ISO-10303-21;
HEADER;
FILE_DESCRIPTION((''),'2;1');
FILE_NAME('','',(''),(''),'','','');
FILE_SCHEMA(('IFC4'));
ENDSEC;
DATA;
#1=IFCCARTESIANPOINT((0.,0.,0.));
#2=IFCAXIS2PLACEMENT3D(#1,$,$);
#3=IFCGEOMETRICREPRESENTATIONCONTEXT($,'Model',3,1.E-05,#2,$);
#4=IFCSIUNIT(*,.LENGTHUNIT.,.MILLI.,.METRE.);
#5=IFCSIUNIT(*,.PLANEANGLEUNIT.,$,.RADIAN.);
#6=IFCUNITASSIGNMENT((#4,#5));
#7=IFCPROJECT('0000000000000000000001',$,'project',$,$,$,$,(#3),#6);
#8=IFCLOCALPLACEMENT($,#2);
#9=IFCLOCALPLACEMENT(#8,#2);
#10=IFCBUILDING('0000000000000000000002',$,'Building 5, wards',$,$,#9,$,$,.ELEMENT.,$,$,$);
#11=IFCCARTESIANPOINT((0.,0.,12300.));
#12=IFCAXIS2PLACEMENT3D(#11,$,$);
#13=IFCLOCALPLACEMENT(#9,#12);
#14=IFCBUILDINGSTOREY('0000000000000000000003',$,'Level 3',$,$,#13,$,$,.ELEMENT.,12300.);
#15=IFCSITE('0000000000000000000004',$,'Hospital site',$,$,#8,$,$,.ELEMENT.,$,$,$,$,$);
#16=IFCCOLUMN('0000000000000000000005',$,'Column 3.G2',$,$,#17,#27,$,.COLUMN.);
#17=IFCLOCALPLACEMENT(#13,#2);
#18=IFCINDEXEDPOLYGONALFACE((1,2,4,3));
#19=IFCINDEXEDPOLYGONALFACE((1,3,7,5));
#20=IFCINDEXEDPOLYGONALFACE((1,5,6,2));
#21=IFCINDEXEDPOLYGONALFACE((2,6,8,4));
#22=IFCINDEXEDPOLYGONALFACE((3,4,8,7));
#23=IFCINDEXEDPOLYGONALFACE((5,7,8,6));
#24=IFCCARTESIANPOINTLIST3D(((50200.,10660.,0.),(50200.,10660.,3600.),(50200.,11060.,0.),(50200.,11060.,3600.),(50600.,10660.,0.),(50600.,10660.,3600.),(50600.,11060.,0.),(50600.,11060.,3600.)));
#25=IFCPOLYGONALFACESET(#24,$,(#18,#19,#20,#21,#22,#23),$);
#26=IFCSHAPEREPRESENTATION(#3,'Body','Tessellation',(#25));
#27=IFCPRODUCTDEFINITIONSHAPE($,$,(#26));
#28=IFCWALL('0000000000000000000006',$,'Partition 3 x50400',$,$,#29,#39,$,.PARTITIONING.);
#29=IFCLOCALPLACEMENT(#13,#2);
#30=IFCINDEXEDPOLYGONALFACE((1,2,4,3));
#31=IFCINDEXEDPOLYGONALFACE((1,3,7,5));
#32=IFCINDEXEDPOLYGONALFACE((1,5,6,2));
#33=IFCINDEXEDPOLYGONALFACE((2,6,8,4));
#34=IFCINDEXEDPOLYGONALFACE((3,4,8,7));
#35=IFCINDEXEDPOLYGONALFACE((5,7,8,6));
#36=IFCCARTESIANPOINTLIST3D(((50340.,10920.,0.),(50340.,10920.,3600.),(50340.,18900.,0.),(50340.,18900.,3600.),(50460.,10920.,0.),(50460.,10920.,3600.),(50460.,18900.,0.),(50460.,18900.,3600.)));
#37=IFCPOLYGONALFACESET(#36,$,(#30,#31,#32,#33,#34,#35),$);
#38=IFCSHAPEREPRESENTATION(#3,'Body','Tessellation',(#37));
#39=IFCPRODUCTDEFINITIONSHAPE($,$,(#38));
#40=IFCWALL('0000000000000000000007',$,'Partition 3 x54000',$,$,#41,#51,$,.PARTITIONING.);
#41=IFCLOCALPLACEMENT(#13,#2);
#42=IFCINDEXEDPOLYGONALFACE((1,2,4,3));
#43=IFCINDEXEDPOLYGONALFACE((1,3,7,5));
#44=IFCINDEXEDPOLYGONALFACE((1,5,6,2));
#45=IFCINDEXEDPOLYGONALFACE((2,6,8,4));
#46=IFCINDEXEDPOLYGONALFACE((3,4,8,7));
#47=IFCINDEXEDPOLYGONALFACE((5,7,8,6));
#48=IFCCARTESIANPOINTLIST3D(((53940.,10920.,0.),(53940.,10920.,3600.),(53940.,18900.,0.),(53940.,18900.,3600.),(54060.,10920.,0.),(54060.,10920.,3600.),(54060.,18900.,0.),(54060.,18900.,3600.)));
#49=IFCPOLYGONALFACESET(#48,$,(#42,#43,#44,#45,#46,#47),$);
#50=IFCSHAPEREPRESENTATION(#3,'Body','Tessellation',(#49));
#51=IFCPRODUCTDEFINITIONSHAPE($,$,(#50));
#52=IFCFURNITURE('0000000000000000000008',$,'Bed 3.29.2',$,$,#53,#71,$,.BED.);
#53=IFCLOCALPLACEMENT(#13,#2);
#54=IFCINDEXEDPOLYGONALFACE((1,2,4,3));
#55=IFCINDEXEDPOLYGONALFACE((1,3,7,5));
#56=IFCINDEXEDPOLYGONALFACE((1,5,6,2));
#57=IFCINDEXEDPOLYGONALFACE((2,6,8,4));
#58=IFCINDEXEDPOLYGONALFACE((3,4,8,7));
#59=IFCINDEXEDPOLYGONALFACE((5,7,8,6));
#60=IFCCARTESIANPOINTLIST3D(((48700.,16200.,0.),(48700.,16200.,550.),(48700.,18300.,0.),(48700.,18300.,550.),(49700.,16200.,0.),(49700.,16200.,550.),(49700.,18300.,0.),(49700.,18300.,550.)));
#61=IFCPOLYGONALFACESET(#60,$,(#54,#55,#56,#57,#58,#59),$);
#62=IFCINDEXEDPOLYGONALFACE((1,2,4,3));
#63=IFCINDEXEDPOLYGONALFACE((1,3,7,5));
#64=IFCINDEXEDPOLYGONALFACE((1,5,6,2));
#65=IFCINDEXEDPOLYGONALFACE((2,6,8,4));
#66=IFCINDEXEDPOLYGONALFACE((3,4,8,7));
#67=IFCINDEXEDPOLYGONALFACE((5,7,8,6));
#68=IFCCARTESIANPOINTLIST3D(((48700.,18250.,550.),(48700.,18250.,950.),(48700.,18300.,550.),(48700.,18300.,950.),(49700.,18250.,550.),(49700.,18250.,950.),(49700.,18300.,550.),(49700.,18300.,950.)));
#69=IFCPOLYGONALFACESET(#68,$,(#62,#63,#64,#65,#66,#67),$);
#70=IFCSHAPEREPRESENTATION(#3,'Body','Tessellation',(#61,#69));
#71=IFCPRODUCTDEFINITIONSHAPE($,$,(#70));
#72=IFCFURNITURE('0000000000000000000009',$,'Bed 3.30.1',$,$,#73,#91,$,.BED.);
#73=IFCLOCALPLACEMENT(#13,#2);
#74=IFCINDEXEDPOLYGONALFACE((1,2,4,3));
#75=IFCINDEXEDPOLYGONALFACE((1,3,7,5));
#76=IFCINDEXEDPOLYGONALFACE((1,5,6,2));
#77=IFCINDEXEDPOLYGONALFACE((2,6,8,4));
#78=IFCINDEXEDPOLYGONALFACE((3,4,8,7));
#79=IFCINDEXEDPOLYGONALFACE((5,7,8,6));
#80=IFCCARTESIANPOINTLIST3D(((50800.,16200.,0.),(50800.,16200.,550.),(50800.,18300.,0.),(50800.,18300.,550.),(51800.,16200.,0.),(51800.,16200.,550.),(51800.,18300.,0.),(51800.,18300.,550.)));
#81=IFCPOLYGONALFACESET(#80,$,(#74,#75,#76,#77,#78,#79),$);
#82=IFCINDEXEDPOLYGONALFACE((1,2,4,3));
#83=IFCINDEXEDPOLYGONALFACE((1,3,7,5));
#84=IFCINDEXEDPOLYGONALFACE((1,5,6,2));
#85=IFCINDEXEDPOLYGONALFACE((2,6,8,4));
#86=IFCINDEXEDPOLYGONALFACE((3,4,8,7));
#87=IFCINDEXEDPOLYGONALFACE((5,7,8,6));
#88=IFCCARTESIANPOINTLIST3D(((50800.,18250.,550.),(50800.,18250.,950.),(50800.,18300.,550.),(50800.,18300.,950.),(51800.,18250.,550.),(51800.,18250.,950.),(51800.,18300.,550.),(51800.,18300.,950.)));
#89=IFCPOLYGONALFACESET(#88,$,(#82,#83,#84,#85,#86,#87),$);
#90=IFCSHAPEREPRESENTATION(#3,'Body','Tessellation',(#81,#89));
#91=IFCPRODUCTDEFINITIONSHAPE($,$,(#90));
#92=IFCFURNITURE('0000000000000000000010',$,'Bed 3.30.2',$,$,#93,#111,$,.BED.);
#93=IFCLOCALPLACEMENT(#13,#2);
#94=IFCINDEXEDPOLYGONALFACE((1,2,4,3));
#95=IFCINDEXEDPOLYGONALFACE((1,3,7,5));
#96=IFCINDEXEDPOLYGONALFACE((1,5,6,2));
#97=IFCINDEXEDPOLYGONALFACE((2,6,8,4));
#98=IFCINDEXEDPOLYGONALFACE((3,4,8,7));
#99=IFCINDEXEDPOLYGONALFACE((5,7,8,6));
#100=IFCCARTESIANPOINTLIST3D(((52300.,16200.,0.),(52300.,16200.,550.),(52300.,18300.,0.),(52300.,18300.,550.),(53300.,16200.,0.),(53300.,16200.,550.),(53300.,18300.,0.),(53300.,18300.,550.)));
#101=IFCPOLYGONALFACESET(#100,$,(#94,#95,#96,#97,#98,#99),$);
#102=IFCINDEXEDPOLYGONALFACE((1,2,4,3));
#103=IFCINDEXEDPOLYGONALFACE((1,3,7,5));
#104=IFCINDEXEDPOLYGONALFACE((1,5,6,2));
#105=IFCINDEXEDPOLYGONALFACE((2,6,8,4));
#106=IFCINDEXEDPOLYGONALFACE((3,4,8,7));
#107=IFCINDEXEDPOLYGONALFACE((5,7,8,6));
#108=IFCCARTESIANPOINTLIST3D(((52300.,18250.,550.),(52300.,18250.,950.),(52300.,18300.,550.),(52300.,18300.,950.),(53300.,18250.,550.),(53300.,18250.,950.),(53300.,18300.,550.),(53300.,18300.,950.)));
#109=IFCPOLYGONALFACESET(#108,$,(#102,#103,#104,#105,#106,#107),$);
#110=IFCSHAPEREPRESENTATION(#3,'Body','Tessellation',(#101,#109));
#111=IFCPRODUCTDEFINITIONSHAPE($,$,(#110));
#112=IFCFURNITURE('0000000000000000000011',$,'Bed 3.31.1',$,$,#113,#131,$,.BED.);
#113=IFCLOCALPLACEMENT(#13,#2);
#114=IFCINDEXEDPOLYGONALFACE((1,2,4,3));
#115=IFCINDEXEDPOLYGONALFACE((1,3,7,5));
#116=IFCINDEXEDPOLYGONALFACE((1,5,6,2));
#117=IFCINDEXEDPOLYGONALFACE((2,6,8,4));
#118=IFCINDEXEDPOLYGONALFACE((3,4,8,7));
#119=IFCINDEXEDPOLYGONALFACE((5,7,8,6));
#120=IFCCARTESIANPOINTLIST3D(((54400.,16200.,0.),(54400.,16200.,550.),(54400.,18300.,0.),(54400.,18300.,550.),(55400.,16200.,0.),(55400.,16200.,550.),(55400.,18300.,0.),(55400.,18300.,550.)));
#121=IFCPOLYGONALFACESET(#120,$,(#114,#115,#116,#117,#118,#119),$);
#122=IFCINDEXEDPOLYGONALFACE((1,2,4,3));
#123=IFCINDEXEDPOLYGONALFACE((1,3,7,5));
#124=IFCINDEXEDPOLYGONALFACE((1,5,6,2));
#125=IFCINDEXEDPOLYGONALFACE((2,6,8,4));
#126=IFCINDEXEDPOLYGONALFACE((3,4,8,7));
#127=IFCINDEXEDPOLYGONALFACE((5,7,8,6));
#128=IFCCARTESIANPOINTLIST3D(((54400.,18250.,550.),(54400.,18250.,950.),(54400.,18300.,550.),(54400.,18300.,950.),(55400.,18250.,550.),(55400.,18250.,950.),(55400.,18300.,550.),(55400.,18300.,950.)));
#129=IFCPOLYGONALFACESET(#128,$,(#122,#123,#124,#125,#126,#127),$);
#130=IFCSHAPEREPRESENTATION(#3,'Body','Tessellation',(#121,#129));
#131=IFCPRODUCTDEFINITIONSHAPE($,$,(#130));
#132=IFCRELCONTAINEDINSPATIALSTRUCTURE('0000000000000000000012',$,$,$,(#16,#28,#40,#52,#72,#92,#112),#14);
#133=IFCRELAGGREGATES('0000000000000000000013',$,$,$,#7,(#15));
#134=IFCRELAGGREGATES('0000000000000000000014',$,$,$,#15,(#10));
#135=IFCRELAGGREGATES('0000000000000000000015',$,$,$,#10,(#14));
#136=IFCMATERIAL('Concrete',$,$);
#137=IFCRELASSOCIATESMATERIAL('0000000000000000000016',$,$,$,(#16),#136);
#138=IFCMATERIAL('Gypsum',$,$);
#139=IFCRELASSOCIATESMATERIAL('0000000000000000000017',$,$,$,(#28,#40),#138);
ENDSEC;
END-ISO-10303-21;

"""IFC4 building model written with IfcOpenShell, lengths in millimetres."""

from ifc_helpers import new_model, si_unit, frame, frame_2d, origin, origin_2d, place, context, project, spatial, rectangle, extrude, material, element, save


model = new_model("IFC4")

# Units and contexts
model_context = context("Model", 3, precision=1e-05, world=origin())
ifc_project = project(units=[si_unit("LENGTHUNIT", "METRE", prefix="MILLI"), si_unit("PLANEANGLEUNIT", "RADIAN")], contexts=[model_context])

# Site, building, storey
site_placement = place(None, origin())
site = spatial("IfcSite", under=ifc_project, at=site_placement, Name="Hospital site", CompositionType="ELEMENT")
building_placement = place(site_placement, origin())
building = spatial("IfcBuilding", under=site, at=building_placement, Name="Building 5, wards", CompositionType="ELEMENT")
storey_placement = place(building_placement, frame((0.0, 0.0, 12300.0)))
storey = spatial("IfcBuildingStorey", under=building, at=storey_placement, Name="Level 3", CompositionType="ELEMENT", Elevation=12300.0)

# Column
ifc_material_1 = material(Name="Concrete")
column_placement = place(storey_placement, frame((50400.0, 10860.0, 0.0)))
element("IfcColumn", 1, at=column_placement, inside=storey, material=ifc_material_1, Name="Column 3.G2", PredefinedType="COLUMN", context=model_context, shape_type="SweptSolid", body=[
    extrude(rectangle(XDim=400.0, YDim=400.0, at=origin_2d()), origin(), (0.0, 0.0, 1.0), 3600.0),
])

# Walls
ifc_material_2 = material(Name="Gypsum")
for number, where, x_axis, name in (
    (2, (50460.0, 10920.0, 0.0), (0.0, 1.0, 0.0), "Partition 3 x50400"),
    (3, (54060.0, 10920.0, 0.0), (0.0, 1.0, 0.0), "Partition 3 x54000"),
):
    element("IfcWall", number, at=place(storey_placement, frame(where, x_axis=x_axis)), inside=storey, material=ifc_material_2, Name=name, PredefinedType="PARTITIONING", context=model_context, shape_type="SweptSolid", body=[
        extrude(rectangle(XDim=7980.0, YDim=120.0, at=frame_2d((3990.0, 60.0))), origin(), (0.0, 0.0, 1.0), 3600.0),
    ])

# Furniture
for number, where, name in (
    (4, (48700.0, 16200.0, 0.0), "Bed 3.29.2"),
    (5, (50800.0, 16200.0, 0.0), "Bed 3.30.1"),
    (6, (52300.0, 16200.0, 0.0), "Bed 3.30.2"),
    (7, (54400.0, 16200.0, 0.0), "Bed 3.31.1"),
):
    element("IfcFurniture", number, at=place(storey_placement, frame(where)), inside=storey, Name=name, PredefinedType="BED", context=model_context, shape_type="SweptSolid", body=[
        extrude(rectangle(XDim=1000.0, YDim=2100.0, at=frame_2d((500.0, 1050.0))), origin(), (0.0, 0.0, 1.0), 550.0),
        extrude(rectangle(XDim=1000.0, YDim=50.0, at=frame_2d((500.0, 2075.0))), frame((0.0, 0.0, 550.0)), (0.0, 0.0, 1.0), 400.0),
    ])

save(model, "model.ifc")
